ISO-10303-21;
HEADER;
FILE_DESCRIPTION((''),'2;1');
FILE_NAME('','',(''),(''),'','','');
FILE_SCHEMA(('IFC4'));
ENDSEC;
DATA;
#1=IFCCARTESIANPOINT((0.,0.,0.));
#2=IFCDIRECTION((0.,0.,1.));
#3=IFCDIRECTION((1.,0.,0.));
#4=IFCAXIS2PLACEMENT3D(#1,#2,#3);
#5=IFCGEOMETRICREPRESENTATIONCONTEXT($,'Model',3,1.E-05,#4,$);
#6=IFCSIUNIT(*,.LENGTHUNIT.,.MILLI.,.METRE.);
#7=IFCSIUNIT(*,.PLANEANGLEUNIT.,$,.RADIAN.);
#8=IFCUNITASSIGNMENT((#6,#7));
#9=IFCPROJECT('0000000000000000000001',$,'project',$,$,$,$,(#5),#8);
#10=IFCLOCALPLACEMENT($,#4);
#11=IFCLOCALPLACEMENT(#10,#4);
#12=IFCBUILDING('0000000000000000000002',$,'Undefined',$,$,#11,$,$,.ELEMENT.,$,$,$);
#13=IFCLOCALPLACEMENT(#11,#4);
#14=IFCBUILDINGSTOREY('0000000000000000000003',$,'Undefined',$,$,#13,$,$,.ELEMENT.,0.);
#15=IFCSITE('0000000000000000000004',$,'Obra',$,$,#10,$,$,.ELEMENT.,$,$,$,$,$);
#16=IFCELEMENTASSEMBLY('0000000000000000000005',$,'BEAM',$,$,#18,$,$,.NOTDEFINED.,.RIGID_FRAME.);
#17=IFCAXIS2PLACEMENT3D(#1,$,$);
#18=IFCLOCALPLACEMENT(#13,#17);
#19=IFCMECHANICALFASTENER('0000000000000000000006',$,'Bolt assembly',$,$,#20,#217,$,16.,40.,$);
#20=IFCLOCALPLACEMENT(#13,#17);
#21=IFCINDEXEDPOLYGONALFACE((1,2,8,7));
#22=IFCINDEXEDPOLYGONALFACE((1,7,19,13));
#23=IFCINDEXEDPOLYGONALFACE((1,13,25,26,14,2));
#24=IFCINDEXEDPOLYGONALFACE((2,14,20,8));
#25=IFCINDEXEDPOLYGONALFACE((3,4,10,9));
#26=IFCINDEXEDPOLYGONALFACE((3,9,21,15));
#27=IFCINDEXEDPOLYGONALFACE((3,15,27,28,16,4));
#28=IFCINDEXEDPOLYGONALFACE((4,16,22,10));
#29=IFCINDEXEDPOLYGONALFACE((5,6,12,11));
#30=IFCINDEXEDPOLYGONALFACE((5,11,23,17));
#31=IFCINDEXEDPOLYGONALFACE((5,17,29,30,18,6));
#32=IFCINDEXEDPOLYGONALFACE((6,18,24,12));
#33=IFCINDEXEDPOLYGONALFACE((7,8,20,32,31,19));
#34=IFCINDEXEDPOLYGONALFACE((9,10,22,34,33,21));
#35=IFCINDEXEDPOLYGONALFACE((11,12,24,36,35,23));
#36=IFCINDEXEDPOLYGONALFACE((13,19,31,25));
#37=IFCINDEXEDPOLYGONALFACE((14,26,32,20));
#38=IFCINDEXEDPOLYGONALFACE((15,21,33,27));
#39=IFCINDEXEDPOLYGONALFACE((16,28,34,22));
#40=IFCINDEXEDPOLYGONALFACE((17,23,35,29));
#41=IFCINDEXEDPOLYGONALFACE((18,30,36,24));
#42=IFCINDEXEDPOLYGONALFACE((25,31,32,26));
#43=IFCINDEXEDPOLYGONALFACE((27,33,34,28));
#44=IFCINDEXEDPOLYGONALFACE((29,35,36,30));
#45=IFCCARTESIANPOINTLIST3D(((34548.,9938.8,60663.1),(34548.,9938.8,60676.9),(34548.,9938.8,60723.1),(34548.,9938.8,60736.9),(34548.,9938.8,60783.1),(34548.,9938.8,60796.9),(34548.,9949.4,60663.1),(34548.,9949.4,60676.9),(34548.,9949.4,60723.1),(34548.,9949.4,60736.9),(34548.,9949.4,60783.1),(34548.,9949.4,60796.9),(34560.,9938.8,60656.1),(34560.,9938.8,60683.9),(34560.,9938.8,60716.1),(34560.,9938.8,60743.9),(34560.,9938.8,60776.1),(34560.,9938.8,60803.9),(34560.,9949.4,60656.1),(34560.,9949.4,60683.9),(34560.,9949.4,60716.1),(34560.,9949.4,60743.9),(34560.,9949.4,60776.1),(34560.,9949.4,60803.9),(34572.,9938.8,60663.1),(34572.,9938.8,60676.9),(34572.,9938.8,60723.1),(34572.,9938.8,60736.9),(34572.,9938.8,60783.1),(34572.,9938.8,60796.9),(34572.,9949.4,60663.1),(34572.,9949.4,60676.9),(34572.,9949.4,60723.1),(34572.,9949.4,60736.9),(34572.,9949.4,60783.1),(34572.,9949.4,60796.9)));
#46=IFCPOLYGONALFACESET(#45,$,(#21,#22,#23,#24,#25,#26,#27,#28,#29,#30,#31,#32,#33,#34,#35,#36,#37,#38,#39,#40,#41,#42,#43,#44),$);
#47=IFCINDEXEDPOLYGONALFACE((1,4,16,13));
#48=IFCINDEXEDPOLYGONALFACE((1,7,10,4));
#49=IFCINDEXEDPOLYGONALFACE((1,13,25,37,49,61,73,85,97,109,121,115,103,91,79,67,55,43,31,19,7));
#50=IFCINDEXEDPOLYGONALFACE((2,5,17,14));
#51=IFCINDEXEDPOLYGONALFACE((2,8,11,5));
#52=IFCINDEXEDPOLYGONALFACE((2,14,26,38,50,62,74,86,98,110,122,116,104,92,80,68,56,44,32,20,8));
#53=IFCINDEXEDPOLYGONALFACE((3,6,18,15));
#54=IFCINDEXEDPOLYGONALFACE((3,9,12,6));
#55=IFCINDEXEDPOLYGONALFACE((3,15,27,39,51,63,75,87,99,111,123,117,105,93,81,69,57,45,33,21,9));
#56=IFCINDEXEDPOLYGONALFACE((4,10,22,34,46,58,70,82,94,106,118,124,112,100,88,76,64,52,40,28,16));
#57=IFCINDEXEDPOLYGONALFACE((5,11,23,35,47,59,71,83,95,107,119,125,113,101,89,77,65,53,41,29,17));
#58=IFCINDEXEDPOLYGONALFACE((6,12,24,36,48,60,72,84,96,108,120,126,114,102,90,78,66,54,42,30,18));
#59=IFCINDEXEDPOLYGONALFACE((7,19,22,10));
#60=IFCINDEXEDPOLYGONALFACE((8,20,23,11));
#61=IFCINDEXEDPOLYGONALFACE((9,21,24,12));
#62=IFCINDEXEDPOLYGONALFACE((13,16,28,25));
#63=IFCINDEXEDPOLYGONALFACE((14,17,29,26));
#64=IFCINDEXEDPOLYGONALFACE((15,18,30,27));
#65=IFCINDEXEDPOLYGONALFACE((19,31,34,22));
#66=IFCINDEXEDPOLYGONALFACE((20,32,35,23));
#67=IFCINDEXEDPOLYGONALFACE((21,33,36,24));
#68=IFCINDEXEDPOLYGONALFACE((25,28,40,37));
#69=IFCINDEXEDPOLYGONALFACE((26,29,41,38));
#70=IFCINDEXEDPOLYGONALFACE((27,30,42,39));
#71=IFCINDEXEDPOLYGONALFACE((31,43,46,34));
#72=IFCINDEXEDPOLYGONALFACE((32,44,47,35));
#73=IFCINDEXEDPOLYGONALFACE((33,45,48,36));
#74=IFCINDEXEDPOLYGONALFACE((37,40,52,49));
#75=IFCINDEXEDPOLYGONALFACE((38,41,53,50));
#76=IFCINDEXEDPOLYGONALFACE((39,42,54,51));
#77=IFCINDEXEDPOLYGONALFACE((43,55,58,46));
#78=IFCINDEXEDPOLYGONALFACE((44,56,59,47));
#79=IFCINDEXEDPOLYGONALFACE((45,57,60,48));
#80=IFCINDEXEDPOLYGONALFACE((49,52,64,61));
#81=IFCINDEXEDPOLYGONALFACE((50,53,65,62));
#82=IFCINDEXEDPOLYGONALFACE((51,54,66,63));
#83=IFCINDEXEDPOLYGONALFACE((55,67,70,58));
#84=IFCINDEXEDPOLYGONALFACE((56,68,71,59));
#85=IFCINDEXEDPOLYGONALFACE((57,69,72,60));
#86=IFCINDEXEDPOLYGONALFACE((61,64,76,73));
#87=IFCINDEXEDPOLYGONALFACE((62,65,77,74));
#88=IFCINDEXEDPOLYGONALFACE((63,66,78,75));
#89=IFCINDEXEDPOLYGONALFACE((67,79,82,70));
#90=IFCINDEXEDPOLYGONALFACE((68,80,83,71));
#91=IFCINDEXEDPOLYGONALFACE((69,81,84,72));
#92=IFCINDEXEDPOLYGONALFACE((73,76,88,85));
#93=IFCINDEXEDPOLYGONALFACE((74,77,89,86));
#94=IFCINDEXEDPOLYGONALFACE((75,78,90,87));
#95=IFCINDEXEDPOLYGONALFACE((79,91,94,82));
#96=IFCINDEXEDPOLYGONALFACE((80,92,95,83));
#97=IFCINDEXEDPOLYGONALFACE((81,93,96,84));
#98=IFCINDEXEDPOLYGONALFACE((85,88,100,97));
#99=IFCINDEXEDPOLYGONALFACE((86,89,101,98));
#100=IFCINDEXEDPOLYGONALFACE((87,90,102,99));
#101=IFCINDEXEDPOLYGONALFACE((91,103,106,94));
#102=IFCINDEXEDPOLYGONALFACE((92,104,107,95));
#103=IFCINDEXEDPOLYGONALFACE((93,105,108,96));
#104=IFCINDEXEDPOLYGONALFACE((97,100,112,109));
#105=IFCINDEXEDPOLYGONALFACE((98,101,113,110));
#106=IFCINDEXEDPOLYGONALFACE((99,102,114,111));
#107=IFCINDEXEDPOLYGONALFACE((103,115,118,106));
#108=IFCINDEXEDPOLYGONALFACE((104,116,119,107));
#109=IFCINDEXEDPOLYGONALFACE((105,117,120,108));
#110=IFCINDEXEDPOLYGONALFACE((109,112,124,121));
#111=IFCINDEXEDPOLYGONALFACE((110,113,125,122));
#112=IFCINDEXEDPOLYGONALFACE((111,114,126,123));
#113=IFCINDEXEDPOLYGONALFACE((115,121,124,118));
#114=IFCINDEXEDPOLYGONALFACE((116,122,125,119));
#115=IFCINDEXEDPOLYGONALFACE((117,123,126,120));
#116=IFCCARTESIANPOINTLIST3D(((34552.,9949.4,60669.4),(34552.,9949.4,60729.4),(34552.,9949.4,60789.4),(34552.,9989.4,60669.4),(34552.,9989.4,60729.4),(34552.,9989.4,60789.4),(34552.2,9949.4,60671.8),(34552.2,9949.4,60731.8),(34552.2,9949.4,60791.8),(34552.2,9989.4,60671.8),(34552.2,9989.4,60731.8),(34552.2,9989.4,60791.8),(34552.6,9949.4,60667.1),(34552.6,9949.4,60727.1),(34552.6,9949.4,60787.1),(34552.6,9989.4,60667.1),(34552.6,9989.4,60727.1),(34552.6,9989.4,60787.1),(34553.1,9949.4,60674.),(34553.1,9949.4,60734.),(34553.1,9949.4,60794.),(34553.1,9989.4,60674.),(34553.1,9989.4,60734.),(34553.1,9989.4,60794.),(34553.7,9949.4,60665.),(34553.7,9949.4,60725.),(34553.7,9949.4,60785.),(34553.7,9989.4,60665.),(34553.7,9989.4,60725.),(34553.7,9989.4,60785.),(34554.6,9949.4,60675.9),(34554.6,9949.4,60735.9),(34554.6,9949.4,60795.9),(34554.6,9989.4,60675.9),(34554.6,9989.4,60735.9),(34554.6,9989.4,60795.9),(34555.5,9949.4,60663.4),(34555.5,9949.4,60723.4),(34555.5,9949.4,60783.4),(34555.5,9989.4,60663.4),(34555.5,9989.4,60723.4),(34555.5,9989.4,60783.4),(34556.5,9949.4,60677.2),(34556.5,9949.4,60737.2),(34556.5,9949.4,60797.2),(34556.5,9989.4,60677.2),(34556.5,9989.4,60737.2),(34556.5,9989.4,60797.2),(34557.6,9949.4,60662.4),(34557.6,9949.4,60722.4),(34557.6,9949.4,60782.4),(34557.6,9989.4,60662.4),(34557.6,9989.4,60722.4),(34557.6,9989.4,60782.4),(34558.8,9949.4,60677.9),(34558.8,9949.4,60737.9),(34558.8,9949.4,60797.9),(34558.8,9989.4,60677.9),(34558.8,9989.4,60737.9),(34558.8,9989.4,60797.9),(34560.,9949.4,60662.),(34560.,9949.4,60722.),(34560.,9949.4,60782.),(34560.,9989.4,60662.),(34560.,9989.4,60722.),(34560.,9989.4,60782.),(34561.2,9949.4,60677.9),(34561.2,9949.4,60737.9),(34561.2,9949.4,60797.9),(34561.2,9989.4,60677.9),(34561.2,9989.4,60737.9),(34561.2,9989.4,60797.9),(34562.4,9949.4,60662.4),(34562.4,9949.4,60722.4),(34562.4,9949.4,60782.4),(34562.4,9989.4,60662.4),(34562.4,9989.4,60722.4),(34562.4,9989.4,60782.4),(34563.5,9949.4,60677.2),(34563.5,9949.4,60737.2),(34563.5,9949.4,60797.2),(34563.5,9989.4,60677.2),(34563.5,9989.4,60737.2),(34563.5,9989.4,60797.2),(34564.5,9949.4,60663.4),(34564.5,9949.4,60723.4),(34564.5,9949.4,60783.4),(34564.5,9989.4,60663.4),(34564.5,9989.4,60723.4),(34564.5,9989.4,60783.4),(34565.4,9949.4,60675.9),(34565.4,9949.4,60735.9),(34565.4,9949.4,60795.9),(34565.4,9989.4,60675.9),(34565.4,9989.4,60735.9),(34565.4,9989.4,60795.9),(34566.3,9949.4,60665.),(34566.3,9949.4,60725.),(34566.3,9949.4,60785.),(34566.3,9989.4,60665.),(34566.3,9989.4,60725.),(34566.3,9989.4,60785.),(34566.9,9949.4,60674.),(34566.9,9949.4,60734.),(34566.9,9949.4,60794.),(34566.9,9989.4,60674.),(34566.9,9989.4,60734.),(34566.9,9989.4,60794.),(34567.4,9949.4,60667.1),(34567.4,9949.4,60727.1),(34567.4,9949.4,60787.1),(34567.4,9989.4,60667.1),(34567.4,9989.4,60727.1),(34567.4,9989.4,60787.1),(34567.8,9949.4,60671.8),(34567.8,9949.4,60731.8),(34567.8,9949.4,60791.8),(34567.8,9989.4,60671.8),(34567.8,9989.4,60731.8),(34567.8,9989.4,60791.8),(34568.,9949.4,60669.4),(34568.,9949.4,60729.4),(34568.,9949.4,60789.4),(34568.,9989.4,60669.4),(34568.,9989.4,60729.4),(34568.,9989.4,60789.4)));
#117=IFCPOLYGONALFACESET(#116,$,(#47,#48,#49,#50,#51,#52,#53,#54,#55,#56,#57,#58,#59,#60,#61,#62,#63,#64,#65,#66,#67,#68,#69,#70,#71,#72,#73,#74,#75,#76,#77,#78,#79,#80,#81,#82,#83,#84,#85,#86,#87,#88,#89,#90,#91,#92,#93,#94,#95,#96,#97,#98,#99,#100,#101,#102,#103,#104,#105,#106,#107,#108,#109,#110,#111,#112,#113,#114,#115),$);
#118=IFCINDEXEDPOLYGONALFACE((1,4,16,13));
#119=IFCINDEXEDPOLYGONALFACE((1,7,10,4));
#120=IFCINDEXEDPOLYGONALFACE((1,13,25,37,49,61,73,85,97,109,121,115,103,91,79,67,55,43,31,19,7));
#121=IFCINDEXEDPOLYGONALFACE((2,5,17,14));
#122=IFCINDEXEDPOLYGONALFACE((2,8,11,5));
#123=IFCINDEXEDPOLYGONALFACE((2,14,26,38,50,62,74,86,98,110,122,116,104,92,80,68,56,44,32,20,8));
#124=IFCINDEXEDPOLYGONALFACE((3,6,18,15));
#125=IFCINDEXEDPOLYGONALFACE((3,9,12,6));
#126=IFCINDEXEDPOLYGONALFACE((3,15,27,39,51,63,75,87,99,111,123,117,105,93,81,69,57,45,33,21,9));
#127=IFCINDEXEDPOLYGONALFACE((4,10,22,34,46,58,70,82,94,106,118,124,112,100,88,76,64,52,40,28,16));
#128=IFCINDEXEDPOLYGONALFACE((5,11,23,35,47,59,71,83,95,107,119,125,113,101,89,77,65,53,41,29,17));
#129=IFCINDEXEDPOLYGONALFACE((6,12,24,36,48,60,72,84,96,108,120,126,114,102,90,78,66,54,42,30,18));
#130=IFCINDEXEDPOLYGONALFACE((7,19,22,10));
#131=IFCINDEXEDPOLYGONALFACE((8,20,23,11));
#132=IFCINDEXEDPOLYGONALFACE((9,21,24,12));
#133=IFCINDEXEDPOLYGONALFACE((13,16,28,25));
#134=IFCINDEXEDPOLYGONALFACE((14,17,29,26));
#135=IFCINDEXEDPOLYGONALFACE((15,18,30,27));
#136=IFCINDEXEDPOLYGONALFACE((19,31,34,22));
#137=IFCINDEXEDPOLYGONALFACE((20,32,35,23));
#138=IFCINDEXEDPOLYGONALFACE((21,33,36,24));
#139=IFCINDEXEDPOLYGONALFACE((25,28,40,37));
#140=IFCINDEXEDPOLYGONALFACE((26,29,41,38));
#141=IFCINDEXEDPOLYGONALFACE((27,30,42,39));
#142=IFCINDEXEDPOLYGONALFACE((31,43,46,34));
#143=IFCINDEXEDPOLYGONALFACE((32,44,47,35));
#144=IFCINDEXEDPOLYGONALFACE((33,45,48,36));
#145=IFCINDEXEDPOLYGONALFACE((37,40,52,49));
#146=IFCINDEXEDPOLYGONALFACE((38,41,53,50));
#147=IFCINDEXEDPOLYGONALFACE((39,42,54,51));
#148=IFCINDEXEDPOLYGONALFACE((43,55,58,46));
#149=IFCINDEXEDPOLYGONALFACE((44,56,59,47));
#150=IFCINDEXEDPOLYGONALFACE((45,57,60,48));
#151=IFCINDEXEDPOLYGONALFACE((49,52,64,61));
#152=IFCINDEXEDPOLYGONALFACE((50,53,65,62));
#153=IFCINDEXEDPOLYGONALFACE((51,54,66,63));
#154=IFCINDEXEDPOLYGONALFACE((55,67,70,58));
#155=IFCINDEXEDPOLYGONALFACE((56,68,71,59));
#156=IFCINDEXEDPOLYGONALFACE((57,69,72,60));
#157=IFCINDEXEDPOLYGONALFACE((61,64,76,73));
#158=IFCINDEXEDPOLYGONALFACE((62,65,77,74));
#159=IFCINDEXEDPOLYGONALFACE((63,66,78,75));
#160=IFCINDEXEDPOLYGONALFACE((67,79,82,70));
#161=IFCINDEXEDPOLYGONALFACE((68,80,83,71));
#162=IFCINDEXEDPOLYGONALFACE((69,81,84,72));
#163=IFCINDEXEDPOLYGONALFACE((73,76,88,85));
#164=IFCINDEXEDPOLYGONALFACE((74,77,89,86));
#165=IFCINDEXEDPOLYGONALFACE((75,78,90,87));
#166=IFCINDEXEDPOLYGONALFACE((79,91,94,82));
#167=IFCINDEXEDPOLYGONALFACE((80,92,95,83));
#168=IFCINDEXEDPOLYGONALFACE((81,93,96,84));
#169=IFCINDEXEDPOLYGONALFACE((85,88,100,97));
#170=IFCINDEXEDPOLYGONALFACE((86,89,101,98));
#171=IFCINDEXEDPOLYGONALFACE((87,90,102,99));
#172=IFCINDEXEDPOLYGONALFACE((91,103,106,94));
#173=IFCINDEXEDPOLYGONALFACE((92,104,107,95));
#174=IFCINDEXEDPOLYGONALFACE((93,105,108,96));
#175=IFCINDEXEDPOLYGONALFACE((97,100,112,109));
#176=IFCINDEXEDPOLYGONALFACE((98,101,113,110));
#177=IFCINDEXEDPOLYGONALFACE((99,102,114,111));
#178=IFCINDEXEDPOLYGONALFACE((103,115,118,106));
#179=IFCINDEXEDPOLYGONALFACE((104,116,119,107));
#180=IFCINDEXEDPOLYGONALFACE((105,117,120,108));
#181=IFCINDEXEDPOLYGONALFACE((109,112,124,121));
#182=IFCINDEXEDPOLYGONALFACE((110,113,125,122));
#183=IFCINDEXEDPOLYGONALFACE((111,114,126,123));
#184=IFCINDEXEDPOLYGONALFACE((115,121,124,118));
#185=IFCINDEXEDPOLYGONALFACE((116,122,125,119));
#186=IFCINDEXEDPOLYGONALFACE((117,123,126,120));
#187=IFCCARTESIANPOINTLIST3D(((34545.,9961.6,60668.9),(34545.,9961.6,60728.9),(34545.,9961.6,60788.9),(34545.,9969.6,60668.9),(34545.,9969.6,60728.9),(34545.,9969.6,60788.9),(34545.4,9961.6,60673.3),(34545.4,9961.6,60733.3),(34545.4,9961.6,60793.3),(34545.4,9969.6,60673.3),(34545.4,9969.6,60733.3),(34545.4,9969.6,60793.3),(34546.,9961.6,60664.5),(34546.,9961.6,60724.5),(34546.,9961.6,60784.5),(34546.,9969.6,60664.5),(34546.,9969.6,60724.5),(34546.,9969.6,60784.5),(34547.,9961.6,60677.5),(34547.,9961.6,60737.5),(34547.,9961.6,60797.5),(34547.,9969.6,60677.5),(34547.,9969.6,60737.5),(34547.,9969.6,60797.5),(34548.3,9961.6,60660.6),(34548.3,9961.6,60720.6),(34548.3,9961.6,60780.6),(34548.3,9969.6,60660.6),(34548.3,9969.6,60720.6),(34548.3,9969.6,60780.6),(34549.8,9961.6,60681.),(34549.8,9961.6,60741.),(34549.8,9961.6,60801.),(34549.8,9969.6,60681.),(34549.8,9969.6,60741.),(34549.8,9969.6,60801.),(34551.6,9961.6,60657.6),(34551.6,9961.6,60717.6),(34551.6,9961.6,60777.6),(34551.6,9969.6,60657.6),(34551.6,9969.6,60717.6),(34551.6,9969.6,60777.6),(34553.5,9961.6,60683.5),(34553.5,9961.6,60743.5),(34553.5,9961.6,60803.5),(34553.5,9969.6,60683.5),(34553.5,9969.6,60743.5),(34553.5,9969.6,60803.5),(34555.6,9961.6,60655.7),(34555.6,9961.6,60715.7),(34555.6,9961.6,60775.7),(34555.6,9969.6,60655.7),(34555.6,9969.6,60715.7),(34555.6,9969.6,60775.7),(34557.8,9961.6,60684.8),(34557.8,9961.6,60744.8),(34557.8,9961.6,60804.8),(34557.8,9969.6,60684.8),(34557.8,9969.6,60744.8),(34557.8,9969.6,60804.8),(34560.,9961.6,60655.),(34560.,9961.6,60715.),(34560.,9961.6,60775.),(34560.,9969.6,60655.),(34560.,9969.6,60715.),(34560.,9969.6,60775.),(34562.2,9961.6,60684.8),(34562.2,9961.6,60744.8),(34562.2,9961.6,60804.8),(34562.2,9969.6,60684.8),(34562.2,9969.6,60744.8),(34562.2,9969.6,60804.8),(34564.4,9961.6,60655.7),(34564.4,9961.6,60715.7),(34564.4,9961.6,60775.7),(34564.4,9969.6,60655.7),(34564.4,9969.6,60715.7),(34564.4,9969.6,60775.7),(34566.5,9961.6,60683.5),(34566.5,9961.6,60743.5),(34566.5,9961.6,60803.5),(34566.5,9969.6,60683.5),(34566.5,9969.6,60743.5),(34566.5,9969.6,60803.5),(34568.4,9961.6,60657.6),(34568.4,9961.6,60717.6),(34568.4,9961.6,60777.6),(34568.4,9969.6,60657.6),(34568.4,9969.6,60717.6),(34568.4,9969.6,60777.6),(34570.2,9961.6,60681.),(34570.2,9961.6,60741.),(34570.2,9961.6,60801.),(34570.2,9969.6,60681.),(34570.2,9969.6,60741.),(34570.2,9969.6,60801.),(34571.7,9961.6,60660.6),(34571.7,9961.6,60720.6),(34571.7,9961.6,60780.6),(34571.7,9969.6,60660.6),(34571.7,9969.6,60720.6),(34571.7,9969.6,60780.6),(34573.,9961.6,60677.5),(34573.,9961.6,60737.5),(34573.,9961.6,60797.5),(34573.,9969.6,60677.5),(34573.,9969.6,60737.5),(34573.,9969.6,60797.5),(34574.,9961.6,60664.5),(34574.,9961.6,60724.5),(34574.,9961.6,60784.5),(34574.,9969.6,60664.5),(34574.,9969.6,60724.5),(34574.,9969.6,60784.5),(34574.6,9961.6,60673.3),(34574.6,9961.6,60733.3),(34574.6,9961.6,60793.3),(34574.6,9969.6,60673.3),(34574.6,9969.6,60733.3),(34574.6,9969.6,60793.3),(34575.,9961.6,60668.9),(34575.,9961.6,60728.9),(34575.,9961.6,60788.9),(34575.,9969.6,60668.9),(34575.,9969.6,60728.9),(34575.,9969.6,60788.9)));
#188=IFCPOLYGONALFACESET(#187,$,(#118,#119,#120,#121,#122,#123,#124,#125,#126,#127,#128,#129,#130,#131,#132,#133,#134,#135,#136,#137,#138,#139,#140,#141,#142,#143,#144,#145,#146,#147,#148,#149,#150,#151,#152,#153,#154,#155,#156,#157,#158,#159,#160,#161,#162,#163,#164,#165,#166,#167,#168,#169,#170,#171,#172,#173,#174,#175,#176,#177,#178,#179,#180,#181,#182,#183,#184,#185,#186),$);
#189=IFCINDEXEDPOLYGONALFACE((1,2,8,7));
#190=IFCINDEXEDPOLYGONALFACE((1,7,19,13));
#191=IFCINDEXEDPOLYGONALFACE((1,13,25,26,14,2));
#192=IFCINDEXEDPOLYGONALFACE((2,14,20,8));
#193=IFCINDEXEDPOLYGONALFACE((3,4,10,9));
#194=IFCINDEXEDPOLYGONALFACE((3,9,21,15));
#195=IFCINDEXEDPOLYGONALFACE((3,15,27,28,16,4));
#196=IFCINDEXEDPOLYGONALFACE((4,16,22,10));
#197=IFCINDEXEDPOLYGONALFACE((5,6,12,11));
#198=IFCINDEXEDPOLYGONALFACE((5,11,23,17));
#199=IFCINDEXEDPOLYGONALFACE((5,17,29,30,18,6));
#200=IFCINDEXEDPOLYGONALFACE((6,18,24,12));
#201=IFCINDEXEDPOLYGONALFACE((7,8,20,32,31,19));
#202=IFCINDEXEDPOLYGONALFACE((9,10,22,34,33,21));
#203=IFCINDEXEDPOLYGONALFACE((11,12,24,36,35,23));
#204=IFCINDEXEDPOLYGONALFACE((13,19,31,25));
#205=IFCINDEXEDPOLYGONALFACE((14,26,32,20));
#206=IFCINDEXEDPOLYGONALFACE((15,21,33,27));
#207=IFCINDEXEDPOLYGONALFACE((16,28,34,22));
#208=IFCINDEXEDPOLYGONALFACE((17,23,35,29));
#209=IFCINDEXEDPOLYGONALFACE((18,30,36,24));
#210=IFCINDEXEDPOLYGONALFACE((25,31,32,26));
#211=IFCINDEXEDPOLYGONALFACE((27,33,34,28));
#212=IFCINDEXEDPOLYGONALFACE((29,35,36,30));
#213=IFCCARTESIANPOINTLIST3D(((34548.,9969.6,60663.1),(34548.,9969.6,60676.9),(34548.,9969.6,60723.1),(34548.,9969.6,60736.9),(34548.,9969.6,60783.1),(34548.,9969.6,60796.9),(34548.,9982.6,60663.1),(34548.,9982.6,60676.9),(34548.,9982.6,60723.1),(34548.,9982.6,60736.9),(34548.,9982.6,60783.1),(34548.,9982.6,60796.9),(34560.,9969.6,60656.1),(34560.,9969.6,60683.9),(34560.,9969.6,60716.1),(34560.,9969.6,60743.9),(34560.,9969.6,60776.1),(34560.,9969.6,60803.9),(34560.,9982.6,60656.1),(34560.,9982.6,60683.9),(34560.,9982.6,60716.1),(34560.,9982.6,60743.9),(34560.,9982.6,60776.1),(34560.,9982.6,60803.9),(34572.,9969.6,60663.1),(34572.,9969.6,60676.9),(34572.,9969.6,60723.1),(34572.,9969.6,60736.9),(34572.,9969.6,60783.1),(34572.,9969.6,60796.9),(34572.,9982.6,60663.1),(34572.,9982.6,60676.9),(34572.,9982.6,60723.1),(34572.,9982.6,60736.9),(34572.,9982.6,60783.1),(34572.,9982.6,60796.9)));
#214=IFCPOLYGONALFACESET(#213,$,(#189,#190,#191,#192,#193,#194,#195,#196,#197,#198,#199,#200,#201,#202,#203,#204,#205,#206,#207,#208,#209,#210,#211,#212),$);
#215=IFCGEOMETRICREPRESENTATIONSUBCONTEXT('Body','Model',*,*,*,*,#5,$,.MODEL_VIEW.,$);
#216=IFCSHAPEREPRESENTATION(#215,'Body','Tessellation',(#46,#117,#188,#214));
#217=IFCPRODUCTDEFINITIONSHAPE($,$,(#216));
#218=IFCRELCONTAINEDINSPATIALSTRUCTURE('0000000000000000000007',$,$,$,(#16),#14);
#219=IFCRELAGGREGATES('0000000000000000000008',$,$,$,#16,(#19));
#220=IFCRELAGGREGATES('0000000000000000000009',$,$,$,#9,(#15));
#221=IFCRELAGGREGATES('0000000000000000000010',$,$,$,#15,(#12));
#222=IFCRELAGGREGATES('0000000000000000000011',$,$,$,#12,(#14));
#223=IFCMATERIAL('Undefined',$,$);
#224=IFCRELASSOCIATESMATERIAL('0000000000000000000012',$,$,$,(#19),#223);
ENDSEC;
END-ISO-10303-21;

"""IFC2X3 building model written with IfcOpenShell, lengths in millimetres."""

from ifc_helpers import new_model, si_unit, frame, origin_with_axes, origin_2d_with_axis, place, context, subcontext, project, spatial, polyline, circle, outline, extrude, source, transform, mapped, material, element, aggregate, save


model = new_model("IFC2X3")

# Units and contexts
model_context = context("Model", 3, precision=1e-05, world=origin_with_axes())
body_context = subcontext(model_context, "Body", "Model", "MODEL_VIEW")
ifc_project = project(units=[si_unit("LENGTHUNIT", "METRE", prefix="MILLI"), si_unit("PLANEANGLEUNIT", "RADIAN")], contexts=[model_context])

# Site, building, storey
site_placement = place(None, origin_with_axes())
site = spatial("IfcSite", under=ifc_project, at=site_placement, Name="Obra", CompositionType="ELEMENT")
building_placement = place(site_placement, origin_with_axes())
building = spatial("IfcBuilding", under=site, at=building_placement, Name="Undefined", CompositionType="ELEMENT")
storey_placement = place(building_placement, origin_with_axes())
storey = spatial("IfcBuildingStorey", under=building, at=storey_placement, Name="Undefined", CompositionType="ELEMENT", Elevation=0.0)

# Shared definitions
ifc_material_1 = material(Name="Undefined")

# Element assembly, mechanical fastener
assembly_1_placement = place(storey_placement, origin_with_axes())
assembly_1 = element("IfcElementAssembly", 1, at=assembly_1_placement, inside=storey, Name="BEAM", AssemblyPlace="NOTDEFINED", PredefinedType="RIGID_FRAME")
shared_shape_1 = source(origin_with_axes(), body_context, "Body", "SweptSolid", [
    extrude(outline(polyline([(13.9, 0.0), (6.9, 12.0), (-6.9, 12.0), (-13.9, 0.0), (-6.9, -12.0), (6.9, -12.0), (13.9, 0.0)])), frame((0.0, -19.7, 0.0), z_axis=(0.0, 1.0, 0.0), x_axis=(1.0, 0.0, 0.0)), (0.0, 0.0, 1.0), 10.6),
    extrude(circle(Radius=8.0, at=origin_2d_with_axis()), frame((0.0, -9.1, 0.0), z_axis=(0.0, 1.0, 0.0), x_axis=(1.0, 0.0, 0.0)), (0.0, 0.0, 1.0), 40.0),
    extrude(circle(Radius=15.0, at=origin_2d_with_axis()), frame((0.0, 3.1, 0.0), z_axis=(0.0, 1.0, 0.0), x_axis=(1.0, 0.0, 0.0)), (0.0, 0.0, 1.0), 8.0),
    extrude(outline(polyline([(13.9, 0.0), (6.9, 12.0), (-6.9, 12.0), (-13.9, 0.0), (-6.9, -12.0), (6.9, -12.0), (13.9, 0.0)])), frame((0.0, 11.1, 0.0), z_axis=(0.0, 1.0, 0.0), x_axis=(1.0, 0.0, 0.0)), (0.0, 0.0, 1.0), 13.0),
])
mechanical_fastener_1_placement = place(assembly_1_placement, frame((34510.0, 9958.5, 60850.0), z_axis=(1.0, 0.0, 0.0), x_axis=(0.0, 0.0, -1.0)))
mechanical_fastener_1 = element("IfcMechanicalFastener", 2, at=mechanical_fastener_1_placement, material=ifc_material_1, Name="Bolt assembly", NominalDiameter=16.0, NominalLength=40.0, context=body_context, shape_type="MappedRepresentation", body=[
    mapped(shared_shape_1, transform((60.0, 0.0, 50.0))),
    mapped(shared_shape_1, transform((120.0, 0.0, 50.0))),
    mapped(shared_shape_1, transform((180.0, 0.0, 50.0))),
])
aggregate(assembly_1, [mechanical_fastener_1])

save(model, "model.ifc")
